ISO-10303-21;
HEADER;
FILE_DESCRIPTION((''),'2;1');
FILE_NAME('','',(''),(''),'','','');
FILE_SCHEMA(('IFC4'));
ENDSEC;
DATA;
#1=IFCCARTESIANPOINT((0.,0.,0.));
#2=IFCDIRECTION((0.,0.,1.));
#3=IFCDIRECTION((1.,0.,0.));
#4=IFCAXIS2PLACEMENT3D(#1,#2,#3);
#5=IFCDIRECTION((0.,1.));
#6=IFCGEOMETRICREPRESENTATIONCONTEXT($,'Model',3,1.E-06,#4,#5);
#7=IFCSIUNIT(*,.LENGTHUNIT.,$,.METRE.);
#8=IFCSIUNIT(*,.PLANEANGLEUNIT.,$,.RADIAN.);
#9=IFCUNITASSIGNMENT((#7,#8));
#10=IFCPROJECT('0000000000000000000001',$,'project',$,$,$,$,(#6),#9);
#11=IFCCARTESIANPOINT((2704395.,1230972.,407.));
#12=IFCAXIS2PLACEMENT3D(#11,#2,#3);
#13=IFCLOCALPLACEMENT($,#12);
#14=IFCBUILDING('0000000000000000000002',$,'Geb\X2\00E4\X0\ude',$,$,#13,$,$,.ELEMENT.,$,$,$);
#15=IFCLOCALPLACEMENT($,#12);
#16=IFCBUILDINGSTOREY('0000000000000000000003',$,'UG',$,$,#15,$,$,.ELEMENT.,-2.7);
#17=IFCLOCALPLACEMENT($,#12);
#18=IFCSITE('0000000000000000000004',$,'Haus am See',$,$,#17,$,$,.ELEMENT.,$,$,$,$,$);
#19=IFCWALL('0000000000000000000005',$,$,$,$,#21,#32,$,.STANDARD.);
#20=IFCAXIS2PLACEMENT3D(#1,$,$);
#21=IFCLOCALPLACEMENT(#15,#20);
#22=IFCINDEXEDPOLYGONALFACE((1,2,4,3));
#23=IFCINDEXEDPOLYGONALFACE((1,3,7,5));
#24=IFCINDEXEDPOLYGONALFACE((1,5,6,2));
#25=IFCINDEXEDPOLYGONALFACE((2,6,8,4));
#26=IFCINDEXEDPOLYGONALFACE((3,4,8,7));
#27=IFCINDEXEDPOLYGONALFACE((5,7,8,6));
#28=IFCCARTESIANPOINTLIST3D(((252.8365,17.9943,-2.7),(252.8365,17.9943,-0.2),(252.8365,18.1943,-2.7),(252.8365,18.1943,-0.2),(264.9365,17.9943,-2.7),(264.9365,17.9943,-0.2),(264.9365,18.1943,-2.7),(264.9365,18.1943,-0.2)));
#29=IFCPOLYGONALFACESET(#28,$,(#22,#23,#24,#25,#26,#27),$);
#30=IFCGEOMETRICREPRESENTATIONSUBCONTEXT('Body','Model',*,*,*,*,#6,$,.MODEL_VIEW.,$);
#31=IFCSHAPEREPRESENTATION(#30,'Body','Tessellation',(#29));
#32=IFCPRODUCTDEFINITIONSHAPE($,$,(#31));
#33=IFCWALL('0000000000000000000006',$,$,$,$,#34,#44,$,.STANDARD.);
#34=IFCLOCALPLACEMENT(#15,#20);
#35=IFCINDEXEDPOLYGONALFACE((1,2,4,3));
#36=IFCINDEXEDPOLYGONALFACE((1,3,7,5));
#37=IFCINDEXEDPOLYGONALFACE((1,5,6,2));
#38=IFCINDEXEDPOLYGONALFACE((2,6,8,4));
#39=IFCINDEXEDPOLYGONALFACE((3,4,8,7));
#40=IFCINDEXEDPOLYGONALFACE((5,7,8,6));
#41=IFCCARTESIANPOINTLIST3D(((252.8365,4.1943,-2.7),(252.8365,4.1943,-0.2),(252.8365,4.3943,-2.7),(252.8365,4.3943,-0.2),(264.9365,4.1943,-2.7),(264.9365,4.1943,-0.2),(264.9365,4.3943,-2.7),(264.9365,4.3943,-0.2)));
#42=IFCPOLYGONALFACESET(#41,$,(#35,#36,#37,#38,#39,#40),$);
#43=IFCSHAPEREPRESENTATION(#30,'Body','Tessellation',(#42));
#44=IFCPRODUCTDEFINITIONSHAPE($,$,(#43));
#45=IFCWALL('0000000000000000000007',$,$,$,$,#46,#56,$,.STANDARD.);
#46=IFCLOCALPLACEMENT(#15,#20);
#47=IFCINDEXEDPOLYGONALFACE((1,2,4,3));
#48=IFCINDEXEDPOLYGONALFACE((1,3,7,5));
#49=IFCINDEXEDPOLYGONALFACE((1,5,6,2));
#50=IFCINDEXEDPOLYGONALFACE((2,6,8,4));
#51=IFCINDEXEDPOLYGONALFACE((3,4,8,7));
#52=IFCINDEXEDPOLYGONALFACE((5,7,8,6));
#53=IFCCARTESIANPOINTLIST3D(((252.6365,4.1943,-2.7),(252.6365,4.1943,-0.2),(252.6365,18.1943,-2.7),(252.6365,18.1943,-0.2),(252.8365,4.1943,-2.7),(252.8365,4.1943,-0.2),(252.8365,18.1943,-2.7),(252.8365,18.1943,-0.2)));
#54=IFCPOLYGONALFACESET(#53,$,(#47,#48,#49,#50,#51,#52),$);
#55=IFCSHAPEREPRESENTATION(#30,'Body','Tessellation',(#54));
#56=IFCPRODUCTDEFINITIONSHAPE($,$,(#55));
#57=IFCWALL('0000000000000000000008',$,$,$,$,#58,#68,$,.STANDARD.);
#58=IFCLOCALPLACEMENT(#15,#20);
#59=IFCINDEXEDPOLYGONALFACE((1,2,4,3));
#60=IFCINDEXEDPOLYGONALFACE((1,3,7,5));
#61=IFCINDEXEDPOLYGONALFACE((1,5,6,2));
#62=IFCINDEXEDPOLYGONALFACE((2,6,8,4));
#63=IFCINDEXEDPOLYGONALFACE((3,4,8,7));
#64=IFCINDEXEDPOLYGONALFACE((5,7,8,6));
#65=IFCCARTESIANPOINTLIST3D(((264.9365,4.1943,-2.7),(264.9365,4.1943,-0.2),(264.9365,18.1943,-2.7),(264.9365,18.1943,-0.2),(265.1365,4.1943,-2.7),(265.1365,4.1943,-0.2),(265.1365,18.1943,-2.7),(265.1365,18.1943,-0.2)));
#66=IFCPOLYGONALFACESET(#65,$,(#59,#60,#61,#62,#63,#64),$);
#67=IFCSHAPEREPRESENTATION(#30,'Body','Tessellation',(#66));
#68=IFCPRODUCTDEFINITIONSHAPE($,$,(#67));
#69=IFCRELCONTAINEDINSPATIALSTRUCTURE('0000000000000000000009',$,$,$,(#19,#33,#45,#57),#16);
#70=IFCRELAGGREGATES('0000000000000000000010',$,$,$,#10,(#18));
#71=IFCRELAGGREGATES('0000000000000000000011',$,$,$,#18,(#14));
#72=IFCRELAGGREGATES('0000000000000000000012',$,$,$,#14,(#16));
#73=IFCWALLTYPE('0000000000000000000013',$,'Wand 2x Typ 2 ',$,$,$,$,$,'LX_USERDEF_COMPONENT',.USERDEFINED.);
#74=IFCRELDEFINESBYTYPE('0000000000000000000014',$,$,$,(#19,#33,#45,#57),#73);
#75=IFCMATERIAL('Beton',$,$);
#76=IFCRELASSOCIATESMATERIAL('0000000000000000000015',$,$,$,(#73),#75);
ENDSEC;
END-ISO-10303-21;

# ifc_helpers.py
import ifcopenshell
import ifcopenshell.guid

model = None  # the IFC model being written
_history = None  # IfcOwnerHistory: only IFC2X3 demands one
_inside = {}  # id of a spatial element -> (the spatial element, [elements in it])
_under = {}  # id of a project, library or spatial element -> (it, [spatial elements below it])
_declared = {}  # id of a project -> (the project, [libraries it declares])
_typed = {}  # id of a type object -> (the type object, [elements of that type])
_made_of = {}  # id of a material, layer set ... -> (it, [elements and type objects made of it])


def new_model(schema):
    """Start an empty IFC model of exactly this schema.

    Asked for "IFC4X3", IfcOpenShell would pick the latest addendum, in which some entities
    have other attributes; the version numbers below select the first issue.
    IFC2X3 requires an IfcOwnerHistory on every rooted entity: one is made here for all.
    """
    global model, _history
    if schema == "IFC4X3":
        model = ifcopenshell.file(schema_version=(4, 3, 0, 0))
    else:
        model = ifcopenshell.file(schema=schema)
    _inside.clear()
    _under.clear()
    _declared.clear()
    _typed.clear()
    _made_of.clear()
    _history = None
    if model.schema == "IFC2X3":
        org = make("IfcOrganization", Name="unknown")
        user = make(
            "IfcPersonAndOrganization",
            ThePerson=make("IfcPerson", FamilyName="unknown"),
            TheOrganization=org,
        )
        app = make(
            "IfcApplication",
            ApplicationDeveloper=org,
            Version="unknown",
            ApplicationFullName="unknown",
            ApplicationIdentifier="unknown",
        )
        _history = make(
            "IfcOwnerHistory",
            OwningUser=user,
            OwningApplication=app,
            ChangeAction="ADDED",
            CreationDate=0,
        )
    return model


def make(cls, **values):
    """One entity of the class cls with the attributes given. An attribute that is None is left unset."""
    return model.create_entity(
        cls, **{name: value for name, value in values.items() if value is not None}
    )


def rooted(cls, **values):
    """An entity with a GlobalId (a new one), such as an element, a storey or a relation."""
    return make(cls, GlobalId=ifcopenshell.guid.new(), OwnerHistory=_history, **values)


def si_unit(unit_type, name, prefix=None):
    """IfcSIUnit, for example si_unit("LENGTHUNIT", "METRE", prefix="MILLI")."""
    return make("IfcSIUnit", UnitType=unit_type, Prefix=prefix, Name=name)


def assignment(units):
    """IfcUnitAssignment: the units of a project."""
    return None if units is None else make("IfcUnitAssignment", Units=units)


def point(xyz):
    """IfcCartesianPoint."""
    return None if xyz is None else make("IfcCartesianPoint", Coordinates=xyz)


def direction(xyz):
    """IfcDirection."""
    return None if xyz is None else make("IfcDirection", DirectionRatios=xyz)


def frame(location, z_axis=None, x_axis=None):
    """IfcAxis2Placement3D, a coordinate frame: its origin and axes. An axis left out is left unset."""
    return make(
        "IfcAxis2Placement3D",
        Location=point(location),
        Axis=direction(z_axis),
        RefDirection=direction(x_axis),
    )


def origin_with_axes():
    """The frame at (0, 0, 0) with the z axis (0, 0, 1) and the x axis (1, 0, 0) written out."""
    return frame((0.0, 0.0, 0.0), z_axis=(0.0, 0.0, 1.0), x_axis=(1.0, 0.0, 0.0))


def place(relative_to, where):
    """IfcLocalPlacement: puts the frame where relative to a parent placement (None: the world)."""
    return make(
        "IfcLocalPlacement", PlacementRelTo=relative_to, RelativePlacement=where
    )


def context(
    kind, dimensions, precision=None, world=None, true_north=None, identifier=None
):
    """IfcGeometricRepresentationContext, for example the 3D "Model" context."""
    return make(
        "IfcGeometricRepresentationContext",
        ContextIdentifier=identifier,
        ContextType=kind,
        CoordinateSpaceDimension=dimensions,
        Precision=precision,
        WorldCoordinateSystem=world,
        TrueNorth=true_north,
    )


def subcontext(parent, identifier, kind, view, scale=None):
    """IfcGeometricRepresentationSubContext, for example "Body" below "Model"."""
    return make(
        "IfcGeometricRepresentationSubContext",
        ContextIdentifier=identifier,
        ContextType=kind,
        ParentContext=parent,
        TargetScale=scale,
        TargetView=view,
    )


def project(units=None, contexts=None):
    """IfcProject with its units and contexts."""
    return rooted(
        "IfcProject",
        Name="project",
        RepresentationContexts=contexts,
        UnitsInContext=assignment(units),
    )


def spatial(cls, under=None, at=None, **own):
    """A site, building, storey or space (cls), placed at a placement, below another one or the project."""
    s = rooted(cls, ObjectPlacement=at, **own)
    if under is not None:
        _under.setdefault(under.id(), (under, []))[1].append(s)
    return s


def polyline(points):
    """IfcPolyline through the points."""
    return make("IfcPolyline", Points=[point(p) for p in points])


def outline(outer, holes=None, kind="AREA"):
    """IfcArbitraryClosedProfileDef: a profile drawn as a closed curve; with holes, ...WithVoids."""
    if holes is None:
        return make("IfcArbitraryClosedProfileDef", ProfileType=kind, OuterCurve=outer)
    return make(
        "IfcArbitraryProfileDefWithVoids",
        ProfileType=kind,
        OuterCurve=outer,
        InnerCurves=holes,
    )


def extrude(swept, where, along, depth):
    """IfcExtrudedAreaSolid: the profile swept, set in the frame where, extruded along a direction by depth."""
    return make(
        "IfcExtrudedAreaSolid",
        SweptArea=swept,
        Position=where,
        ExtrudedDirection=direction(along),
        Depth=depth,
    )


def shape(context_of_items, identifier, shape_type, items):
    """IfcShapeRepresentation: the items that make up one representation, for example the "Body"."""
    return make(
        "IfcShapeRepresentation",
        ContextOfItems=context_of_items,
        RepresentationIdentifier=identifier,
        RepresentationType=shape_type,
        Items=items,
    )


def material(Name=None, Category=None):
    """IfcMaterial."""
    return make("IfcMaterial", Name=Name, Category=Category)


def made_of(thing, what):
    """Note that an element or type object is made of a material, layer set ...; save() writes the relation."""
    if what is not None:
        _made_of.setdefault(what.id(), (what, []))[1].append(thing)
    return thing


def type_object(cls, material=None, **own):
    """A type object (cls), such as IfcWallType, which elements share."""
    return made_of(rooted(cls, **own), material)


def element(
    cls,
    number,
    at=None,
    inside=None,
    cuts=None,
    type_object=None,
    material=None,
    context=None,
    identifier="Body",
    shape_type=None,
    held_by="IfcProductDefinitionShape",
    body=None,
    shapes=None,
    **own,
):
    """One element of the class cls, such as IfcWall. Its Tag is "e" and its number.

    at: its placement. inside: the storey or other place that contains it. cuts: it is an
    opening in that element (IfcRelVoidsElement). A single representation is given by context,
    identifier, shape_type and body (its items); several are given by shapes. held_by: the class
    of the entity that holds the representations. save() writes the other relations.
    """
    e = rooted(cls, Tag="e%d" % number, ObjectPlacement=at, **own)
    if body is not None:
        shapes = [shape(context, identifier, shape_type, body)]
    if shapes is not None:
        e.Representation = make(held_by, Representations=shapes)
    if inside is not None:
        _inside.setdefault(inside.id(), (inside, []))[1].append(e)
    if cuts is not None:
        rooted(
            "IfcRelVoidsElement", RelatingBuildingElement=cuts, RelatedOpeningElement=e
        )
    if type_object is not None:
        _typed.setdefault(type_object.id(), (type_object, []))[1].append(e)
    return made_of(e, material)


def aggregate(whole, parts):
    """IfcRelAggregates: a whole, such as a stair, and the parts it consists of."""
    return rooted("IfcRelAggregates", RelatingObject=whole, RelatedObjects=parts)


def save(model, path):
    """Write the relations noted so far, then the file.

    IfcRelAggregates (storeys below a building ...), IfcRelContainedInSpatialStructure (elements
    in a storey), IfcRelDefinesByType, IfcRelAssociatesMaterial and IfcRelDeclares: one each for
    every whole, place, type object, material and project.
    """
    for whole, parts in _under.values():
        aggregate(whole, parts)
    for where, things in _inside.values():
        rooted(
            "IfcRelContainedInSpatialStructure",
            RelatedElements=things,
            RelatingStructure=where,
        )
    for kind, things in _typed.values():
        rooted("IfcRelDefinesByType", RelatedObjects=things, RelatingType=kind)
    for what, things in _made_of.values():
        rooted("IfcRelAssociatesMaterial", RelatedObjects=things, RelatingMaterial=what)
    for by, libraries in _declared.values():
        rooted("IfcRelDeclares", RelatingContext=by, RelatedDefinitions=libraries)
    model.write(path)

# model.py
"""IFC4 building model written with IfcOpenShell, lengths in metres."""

from ifc_helpers import new_model, si_unit, direction, frame, origin_with_axes, place, context, subcontext, project, spatial, polyline, outline, extrude, material, type_object, element, save


model = new_model("IFC4")

# Units and contexts
model_context = context("Model", 3, precision=1e-06, world=origin_with_axes(), true_north=direction((0.0, 1.0)))
body_context = subcontext(model_context, "Body", "Model", "MODEL_VIEW")
ifc_project = project(units=[si_unit("LENGTHUNIT", "METRE"), si_unit("PLANEANGLEUNIT", "RADIAN")], contexts=[model_context])

# Site, building, storey
site_placement = place(None, frame((2704395.0, 1230972.0, 407.0), z_axis=(0.0, 0.0, 1.0), x_axis=(1.0, 0.0, 0.0)))
site = spatial("IfcSite", under=ifc_project, at=site_placement, Name="Haus am See", CompositionType="ELEMENT")
building_placement = place(None, frame((2704395.0, 1230972.0, 407.0), z_axis=(0.0, 0.0, 1.0), x_axis=(1.0, 0.0, 0.0)))
building = spatial("IfcBuilding", under=site, at=building_placement, Name="Gebäude", CompositionType="ELEMENT")
storey_placement = place(None, frame((2704395.0, 1230972.0, 407.0), z_axis=(0.0, 0.0, 1.0), x_axis=(1.0, 0.0, 0.0)))
storey = spatial("IfcBuildingStorey", under=building, at=storey_placement, Name="UG", CompositionType="ELEMENT", Elevation=-2.7)

# Walls
ifc_material_1 = material(Name="Beton")
wall_type = type_object("IfcWallType", Name="Wand 2x Typ 2 ", ElementType="LX_USERDEF_COMPONENT", PredefinedType="USERDEFINED", material=ifc_material_1)
wall_1_placement = place(storey_placement, frame((264.9365, 18.1943, -2.7), z_axis=(0.0, 0.0, 1.0), x_axis=(-1.0, 0.0, 0.0)))
element("IfcWall", 1, at=wall_1_placement, inside=storey, type_object=wall_type, PredefinedType="STANDARD", context=body_context, shape_type="SweptSolid", body=[
    extrude(outline(polyline([(0.0, 0.0, 0.0), (12.1, 0.0, 0.0), (12.1, 0.2, 0.0), (0.0, 0.2, 0.0), (0.0, 0.0, 0.0)])), origin_with_axes(), (0.0, 0.0, 1.0), 2.5),
])
wall_2_placement = place(storey_placement, frame((252.8365, 4.1943, -2.7), z_axis=(0.0, 0.0, 1.0), x_axis=(1.0, 0.0, 0.0)))
element("IfcWall", 2, at=wall_2_placement, inside=storey, type_object=wall_type, PredefinedType="STANDARD", context=body_context, shape_type="SweptSolid", body=[
    extrude(outline(polyline([(0.0, 0.0, 0.0), (12.1, 0.0, 0.0), (12.1, 0.2, 0.0), (0.0, 0.2, 0.0), (0.0, 0.0, 0.0)])), origin_with_axes(), (0.0, 0.0, 1.0), 2.5),
])
wall_3_placement = place(storey_placement, frame((252.6365, 18.1943, -2.7), z_axis=(0.0, 0.0, 1.0), x_axis=(0.0, -1.0, 0.0)))
element("IfcWall", 3, at=wall_3_placement, inside=storey, type_object=wall_type, PredefinedType="STANDARD", context=body_context, shape_type="SweptSolid", body=[
    extrude(outline(polyline([(0.0, 0.0, 0.0), (14.0, 0.0, 0.0), (14.0, 0.2, 0.0), (0.0, 0.2, 0.0), (0.0, 0.0, 0.0)])), origin_with_axes(), (0.0, 0.0, 1.0), 2.5),
])
wall_4_placement = place(storey_placement, frame((265.1365, 4.1943, -2.7), z_axis=(0.0, 0.0, 1.0), x_axis=(0.0, 1.0, 0.0)))
element("IfcWall", 4, at=wall_4_placement, inside=storey, type_object=wall_type, PredefinedType="STANDARD", context=body_context, shape_type="SweptSolid", body=[
    extrude(outline(polyline([(0.0, 0.0, 0.0), (14.0, 0.0, 0.0), (14.0, 0.2, 0.0), (0.0, 0.2, 0.0), (0.0, 0.0, 0.0)])), origin_with_axes(), (0.0, 0.0, 1.0), 2.5),
])

save(model, "model.ifc")
